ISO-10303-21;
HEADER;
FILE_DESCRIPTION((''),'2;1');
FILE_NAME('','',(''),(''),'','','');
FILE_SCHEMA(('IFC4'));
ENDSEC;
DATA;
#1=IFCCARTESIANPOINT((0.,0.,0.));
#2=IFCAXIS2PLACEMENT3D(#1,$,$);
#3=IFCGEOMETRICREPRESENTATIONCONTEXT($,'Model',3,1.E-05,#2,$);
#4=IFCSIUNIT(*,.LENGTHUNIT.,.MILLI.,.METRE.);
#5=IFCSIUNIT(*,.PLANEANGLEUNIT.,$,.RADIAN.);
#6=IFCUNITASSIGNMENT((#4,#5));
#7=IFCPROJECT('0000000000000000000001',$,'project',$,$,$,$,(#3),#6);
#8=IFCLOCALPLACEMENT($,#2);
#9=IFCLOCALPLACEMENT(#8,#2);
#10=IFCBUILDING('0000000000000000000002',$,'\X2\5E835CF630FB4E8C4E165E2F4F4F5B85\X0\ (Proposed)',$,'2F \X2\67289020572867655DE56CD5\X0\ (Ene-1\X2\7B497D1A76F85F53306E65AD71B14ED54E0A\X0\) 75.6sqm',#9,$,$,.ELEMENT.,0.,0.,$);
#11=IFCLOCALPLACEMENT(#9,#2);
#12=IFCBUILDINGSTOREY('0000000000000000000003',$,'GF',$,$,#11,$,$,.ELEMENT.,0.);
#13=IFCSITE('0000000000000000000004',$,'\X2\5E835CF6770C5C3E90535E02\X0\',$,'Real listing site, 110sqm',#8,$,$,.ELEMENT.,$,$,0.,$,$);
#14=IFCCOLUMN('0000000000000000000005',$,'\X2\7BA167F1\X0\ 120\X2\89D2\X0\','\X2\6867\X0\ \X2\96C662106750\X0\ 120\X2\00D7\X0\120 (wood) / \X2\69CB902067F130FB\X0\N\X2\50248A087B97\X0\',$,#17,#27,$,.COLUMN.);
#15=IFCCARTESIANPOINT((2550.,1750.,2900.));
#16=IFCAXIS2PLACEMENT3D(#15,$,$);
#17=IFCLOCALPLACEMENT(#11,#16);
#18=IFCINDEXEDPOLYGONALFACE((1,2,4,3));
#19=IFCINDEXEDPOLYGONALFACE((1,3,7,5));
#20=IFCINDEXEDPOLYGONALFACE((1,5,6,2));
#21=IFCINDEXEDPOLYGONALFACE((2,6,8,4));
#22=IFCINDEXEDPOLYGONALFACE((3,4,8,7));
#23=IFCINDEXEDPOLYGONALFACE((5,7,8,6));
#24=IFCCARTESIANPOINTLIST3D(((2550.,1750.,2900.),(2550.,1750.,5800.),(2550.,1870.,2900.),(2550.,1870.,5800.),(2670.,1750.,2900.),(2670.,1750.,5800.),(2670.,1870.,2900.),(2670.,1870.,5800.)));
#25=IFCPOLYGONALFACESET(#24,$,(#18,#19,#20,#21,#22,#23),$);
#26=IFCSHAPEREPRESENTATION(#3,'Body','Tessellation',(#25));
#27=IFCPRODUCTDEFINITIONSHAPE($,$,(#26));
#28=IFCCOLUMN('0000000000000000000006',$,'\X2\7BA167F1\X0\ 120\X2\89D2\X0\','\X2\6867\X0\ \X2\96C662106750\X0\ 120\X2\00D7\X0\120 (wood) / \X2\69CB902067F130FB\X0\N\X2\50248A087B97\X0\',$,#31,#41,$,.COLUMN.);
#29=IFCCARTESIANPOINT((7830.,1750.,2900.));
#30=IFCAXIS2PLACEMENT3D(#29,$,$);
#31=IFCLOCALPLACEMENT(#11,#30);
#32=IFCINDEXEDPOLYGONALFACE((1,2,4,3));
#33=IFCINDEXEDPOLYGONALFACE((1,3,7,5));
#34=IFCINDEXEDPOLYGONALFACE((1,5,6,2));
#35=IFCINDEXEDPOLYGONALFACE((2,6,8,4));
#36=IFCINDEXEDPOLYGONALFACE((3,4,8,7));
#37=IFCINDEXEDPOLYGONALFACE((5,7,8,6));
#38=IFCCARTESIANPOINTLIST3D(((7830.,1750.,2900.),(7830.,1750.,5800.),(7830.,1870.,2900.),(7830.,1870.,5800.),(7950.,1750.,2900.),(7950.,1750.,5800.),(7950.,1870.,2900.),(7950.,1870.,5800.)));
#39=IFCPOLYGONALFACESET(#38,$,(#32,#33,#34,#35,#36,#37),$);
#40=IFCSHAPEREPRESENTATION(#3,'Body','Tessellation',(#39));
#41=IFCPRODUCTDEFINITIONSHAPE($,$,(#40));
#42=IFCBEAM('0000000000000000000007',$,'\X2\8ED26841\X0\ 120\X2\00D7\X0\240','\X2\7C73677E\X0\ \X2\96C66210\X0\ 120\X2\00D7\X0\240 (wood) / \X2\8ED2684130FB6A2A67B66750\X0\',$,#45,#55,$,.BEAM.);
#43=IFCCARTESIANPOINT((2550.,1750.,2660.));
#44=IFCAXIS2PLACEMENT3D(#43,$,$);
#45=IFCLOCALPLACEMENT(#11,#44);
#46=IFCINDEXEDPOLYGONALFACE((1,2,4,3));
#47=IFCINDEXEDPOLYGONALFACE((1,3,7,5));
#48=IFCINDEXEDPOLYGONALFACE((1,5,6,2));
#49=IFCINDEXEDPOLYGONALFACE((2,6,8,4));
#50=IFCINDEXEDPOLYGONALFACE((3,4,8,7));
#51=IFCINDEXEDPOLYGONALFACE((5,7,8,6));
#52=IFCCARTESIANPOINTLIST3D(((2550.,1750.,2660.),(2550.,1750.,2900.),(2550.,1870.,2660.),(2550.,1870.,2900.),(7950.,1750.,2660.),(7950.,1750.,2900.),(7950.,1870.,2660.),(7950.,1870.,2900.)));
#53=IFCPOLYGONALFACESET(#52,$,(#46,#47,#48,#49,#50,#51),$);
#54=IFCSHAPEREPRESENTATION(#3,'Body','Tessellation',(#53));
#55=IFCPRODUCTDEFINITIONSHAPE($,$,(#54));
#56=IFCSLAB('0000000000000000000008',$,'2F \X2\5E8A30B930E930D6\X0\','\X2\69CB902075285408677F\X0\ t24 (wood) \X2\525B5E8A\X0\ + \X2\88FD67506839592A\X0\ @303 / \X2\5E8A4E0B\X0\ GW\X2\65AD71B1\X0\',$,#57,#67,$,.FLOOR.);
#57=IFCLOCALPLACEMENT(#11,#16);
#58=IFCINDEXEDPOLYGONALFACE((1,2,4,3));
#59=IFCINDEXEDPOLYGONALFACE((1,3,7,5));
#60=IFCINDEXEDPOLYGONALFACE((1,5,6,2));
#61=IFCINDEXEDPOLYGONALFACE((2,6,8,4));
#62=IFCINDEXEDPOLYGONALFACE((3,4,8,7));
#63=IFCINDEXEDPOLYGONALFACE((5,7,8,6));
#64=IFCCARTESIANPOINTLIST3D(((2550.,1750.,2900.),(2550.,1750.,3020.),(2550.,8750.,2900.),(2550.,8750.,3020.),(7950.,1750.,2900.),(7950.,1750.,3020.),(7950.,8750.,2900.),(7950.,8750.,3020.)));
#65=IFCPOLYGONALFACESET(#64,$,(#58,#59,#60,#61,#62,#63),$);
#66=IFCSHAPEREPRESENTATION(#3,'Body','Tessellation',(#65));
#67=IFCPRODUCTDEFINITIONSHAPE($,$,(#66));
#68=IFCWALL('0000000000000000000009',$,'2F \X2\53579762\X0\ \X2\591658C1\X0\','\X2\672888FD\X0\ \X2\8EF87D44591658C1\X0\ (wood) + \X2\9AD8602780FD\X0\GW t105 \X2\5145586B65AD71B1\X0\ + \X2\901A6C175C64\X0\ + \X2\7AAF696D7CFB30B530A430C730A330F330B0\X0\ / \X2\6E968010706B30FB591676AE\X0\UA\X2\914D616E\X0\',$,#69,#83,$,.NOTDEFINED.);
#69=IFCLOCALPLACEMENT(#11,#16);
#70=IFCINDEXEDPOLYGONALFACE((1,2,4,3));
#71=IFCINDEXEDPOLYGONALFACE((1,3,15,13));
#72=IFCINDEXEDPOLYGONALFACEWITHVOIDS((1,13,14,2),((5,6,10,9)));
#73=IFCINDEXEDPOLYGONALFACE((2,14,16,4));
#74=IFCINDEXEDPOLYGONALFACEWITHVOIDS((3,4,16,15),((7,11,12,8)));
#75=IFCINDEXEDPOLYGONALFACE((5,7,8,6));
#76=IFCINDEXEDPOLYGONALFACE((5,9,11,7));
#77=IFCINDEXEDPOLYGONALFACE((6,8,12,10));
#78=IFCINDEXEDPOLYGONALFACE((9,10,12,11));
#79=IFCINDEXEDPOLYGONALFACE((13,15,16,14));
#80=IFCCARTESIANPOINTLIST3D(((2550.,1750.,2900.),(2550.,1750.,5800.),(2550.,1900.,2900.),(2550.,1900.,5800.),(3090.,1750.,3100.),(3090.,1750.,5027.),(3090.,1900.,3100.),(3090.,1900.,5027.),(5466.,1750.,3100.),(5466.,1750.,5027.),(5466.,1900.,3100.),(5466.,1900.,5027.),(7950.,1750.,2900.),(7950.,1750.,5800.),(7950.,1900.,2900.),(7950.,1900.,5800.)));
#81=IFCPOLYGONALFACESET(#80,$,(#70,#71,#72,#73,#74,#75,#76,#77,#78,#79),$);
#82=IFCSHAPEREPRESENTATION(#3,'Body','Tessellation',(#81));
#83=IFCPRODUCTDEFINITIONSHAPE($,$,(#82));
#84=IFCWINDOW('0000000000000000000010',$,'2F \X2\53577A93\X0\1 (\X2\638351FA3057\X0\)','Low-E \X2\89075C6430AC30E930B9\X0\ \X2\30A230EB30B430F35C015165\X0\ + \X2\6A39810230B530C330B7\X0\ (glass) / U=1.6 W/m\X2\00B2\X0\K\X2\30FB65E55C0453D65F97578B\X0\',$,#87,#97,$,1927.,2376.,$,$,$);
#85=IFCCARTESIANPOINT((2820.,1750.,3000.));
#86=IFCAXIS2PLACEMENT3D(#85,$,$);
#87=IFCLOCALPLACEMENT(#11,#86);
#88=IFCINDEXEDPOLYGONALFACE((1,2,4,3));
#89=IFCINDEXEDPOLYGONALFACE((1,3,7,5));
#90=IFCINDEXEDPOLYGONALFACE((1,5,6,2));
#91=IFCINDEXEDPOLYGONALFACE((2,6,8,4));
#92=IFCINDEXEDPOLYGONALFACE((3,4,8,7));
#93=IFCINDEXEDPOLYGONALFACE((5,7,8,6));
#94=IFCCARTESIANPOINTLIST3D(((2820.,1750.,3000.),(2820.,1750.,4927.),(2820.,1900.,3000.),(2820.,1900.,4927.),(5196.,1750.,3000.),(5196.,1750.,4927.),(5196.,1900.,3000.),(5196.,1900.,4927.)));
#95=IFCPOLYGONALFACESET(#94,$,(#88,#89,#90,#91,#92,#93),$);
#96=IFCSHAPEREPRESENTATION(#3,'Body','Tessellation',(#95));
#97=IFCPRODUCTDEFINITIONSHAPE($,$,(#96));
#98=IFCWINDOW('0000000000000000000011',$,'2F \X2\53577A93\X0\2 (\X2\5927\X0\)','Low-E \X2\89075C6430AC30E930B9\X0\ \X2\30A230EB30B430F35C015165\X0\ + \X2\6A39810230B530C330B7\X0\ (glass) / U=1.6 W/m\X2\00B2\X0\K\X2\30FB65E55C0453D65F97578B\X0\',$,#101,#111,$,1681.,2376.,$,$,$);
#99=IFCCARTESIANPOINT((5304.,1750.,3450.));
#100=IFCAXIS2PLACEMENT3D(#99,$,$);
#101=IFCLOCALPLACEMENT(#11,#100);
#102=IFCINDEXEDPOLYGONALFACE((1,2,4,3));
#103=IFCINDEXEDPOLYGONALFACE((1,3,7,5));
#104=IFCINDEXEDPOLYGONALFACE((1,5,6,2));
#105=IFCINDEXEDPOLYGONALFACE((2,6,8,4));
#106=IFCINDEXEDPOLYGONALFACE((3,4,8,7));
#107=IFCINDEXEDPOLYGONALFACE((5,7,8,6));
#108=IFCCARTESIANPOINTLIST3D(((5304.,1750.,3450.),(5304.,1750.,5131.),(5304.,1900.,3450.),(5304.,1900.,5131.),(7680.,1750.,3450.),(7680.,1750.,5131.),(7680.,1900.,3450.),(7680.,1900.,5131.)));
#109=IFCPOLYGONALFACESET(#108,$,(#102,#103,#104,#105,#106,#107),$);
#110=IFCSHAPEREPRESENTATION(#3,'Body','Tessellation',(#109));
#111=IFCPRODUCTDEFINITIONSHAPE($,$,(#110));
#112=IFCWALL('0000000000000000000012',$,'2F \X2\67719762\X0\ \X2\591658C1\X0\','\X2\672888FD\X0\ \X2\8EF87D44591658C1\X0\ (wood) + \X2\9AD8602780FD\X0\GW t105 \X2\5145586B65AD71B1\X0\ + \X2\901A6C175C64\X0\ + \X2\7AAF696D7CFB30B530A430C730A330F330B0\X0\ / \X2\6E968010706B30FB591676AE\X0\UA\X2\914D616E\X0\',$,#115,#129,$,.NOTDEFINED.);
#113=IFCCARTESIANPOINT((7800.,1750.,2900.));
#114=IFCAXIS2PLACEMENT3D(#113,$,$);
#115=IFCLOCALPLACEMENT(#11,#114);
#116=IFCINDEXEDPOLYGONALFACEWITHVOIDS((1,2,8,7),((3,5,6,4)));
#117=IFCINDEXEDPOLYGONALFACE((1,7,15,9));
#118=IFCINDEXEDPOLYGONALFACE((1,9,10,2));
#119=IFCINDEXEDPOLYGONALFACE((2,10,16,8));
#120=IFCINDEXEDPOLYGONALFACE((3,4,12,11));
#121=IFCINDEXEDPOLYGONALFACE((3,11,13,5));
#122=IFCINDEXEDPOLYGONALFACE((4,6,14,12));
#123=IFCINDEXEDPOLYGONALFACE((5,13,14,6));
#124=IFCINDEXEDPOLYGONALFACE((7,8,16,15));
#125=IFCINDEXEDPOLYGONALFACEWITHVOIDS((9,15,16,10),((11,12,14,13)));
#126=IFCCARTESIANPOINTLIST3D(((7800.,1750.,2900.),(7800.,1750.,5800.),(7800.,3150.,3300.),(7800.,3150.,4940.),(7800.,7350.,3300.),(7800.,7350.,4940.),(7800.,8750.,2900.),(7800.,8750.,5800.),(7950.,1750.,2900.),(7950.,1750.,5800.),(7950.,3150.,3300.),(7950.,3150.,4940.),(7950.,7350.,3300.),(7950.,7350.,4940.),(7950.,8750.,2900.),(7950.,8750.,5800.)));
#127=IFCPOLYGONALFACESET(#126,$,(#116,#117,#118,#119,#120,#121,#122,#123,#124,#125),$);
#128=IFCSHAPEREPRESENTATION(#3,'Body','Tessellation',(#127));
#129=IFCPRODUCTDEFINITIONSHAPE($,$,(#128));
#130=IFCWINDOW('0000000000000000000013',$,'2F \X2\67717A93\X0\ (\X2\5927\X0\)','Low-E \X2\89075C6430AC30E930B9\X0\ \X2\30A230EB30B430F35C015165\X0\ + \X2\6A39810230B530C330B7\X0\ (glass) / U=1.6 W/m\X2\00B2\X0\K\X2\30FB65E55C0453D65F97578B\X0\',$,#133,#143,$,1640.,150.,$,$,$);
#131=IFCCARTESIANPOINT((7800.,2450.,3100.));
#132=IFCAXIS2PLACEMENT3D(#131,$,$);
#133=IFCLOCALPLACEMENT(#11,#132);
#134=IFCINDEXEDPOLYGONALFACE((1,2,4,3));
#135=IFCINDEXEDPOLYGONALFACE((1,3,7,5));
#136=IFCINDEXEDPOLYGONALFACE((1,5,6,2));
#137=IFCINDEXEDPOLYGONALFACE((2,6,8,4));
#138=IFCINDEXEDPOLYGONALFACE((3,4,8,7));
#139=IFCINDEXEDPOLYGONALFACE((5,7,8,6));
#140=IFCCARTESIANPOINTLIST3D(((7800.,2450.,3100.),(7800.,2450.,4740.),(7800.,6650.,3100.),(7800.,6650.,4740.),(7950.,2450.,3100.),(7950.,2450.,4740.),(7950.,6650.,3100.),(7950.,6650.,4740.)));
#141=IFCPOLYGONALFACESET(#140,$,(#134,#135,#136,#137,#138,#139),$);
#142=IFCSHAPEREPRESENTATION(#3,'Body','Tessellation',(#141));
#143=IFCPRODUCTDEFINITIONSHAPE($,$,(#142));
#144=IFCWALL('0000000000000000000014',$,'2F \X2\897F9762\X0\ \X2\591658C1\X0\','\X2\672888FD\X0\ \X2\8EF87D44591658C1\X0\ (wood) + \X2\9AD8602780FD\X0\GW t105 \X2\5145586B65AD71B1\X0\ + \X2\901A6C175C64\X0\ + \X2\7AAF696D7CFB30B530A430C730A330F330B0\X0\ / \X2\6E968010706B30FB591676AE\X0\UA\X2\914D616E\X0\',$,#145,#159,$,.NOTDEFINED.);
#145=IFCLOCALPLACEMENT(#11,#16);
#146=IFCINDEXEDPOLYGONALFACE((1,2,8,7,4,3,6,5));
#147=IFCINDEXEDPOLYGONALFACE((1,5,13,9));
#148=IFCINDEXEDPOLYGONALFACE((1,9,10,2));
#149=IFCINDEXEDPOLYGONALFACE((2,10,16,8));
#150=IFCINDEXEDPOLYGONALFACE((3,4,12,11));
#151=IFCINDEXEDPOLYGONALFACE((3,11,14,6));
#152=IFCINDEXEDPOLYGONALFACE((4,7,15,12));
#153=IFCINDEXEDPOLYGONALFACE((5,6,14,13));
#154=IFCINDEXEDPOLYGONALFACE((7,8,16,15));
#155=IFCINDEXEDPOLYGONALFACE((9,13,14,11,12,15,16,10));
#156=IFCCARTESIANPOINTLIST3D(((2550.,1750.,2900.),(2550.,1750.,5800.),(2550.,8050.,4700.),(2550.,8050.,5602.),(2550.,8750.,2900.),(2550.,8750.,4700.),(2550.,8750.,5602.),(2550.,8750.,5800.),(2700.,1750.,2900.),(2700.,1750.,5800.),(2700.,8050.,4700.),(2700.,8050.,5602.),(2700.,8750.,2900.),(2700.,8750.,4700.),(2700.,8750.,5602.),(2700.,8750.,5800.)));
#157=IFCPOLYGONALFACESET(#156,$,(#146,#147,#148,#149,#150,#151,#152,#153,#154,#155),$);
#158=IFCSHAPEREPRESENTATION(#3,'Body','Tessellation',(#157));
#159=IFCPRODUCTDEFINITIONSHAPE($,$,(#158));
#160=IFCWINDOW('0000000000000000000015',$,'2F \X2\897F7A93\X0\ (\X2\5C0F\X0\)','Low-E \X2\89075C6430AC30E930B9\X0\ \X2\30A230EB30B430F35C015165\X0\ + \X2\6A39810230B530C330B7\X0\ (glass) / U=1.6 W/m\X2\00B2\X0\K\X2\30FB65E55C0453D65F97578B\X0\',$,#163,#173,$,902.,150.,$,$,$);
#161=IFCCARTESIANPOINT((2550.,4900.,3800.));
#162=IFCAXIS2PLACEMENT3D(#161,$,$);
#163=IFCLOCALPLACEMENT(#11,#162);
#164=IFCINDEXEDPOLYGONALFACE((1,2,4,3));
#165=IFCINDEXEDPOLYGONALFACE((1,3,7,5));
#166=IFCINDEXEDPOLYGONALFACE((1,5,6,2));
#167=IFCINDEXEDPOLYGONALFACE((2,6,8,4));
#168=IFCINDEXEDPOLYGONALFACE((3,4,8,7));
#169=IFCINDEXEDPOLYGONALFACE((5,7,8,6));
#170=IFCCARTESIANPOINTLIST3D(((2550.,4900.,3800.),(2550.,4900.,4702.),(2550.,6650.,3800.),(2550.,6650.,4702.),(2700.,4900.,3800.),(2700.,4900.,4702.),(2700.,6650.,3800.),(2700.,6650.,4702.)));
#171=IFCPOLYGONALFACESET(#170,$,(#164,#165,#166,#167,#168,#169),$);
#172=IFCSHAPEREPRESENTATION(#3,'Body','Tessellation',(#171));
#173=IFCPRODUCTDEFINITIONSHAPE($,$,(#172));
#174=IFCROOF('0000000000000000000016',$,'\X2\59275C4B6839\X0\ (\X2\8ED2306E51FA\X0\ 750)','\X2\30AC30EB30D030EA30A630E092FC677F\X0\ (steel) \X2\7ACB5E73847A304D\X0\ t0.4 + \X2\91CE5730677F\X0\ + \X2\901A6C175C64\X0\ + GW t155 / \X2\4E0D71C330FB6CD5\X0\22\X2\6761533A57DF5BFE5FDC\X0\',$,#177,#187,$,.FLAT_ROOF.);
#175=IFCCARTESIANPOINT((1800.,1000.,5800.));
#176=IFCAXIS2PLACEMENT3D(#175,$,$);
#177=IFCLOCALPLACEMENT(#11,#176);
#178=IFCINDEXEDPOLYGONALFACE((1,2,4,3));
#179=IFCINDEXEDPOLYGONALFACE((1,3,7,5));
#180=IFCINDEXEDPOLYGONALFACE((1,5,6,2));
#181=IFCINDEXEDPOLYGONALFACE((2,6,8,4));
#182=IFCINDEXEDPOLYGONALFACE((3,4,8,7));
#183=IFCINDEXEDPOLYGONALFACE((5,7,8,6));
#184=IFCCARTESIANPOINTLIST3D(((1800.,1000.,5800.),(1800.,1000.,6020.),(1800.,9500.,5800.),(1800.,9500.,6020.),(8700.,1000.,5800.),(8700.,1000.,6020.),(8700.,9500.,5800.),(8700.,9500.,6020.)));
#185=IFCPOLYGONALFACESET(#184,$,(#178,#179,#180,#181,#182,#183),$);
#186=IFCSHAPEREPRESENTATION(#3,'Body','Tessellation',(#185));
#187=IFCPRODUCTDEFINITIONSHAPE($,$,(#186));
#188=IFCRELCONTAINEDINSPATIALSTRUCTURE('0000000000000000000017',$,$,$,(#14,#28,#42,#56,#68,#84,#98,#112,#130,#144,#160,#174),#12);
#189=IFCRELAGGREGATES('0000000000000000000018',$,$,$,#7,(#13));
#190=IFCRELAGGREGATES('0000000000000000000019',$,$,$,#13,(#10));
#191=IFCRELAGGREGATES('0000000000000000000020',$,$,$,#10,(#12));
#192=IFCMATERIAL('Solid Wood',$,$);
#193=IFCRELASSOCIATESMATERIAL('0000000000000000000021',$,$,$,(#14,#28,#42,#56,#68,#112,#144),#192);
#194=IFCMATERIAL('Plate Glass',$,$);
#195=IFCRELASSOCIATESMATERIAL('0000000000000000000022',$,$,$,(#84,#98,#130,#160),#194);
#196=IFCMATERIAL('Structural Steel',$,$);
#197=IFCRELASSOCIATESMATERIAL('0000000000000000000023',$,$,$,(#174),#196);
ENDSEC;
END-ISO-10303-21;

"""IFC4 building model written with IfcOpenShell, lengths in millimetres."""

from ifc_helpers import new_model, si_unit, frame, frame_2d, origin, place, context, project, spatial, rectangle, extrude, material, element, fill, save


model = new_model("IFC4")

# Units and contexts
model_context = context("Model", 3, precision=1e-05, world=origin())
ifc_project = project(units=[si_unit("LENGTHUNIT", "METRE", prefix="MILLI"), si_unit("PLANEANGLEUNIT", "RADIAN")], contexts=[model_context])

# Site, building, storey
site_placement = place(None, origin())
site = spatial("IfcSite", under=ifc_project, at=site_placement, Name="広島県尾道市", ObjectType="Real listing site, 110sqm", CompositionType="ELEMENT", RefElevation=0.0)
building_placement = place(site_placement, origin())
building = spatial("IfcBuilding", under=site, at=building_placement, Name="広島・二世帯住宅 (Proposed)", ObjectType="2F 木造在来工法 (Ene-1等級相当の断熱仕上) 75.6sqm", CompositionType="ELEMENT", ElevationOfRefHeight=0.0, ElevationOfTerrain=0.0)
storey_placement = place(building_placement, origin())
storey = spatial("IfcBuildingStorey", under=building, at=storey_placement, Name="GF", CompositionType="ELEMENT", Elevation=0.0)

# Columns
ifc_material_1 = material(Name="Solid Wood")
column_1_placement = place(storey_placement, frame((2550.0, 1750.0, 2900.0)))
element("IfcColumn", 1, at=column_1_placement, inside=storey, material=ifc_material_1, Name="管柱 120角", Description="桧 集成材 120×120 (wood) / 構造柱・N値計算", PredefinedType="COLUMN", context=model_context, shape_type="SweptSolid", body=[
    extrude(rectangle(XDim=120.0, YDim=120.0, at=frame_2d((60.0, 60.0))), frame((2550.0, 1750.0, 2900.0)), (0.0, 0.0, 1.0), 2900.0),
])
column_2_placement = place(storey_placement, frame((7830.0, 1750.0, 2900.0)))
element("IfcColumn", 2, at=column_2_placement, inside=storey, material=ifc_material_1, Name="管柱 120角", Description="桧 集成材 120×120 (wood) / 構造柱・N値計算", PredefinedType="COLUMN", context=model_context, shape_type="SweptSolid", body=[
    extrude(rectangle(XDim=120.0, YDim=120.0, at=frame_2d((60.0, 60.0))), frame((7830.0, 1750.0, 2900.0)), (0.0, 0.0, 1.0), 2900.0),
])

# Beam
beam_1_placement = place(storey_placement, frame((2550.0, 1750.0, 2660.0)))
element("IfcBeam", 3, at=beam_1_placement, inside=storey, material=ifc_material_1, Name="軒桁 120×240", Description="米松 集成 120×240 (wood) / 軒桁・横架材", PredefinedType="BEAM", context=model_context, shape_type="SweptSolid", body=[
    extrude(rectangle(XDim=5400.0, YDim=120.0, at=frame_2d((2700.0, 60.0))), frame((2550.0, 1750.0, 2660.0)), (0.0, 0.0, 1.0), 240.0),
])

# Slab
slab_placement = place(storey_placement, frame((2550.0, 1750.0, 2900.0)))
element("IfcSlab", 4, at=slab_placement, inside=storey, material=ifc_material_1, Name="2F 床スラブ", Description="構造用合板 t24 (wood) 剛床 + 製材根太 @303 / 床下 GW断熱", PredefinedType="FLOOR", context=model_context, shape_type="SweptSolid", body=[
    extrude(rectangle(XDim=5400.0, YDim=7000.0, at=frame_2d((2700.0, 3500.0))), frame((2550.0, 1750.0, 2900.0)), (0.0, 0.0, 1.0), 120.0),
])

# Wall, openings, windows
wall_1_placement = place(storey_placement, frame((2550.0, 1750.0, 2900.0)))
wall_1 = element("IfcWall", 5, at=wall_1_placement, inside=storey, material=ifc_material_1, Name="2F 南面 外壁", Description="木製 軸組外壁 (wood) + 高性能GW t105 充填断熱 + 通気層 + 窯業系サイディング / 準耐火・外皮UA配慮", PredefinedType="NOTDEFINED", context=model_context, shape_type="SweptSolid", body=[
    extrude(rectangle(XDim=5400.0, YDim=150.0, at=frame_2d((2700.0, 75.0))), frame((2550.0, 1750.0, 2900.0)), (0.0, 0.0, 1.0), 2900.0),
])
opening_1_placement = place(storey_placement, frame((2820.0, 1750.0, 3000.0)))
opening_1 = element("IfcOpeningElement", 6, at=opening_1_placement, cuts=wall_1, PredefinedType="NOTDEFINED", context=model_context, shape_type="SweptSolid", body=[
    extrude(rectangle(XDim=2376.0, YDim=150.0, at=frame_2d((1188.0, 75.0))), frame((2820.0, 1750.0, 3000.0)), (0.0, 0.0, 1.0), 1927.0),
])
opening_2_placement = place(storey_placement, frame((5304.0, 1750.0, 3450.0)))
opening_2 = element("IfcOpeningElement", 7, at=opening_2_placement, cuts=wall_1, PredefinedType="NOTDEFINED", context=model_context, shape_type="SweptSolid", body=[
    extrude(rectangle(XDim=2376.0, YDim=150.0, at=frame_2d((1188.0, 75.0))), frame((5304.0, 1750.0, 3450.0)), (0.0, 0.0, 1.0), 1681.0),
])
ifc_material_2 = material(Name="Plate Glass")
window_1_placement = place(storey_placement, frame((2820.0, 1750.0, 3000.0)))
window_1 = element("IfcWindow", 8, at=window_1_placement, inside=storey, material=ifc_material_2, Name="2F 南窓1 (掃出し)", Description="Low-E 複層ガラス アルゴン封入 + 樹脂サッシ (glass) / U=1.6 W/m²K・日射取得型", OverallHeight=1927.0, OverallWidth=2376.0, context=model_context, shape_type="SweptSolid", body=[
    extrude(rectangle(XDim=2376.0, YDim=150.0, at=frame_2d((1188.0, 75.0))), frame((2820.0, 1750.0, 3000.0)), (0.0, 0.0, 1.0), 1927.0),
])
fill(opening_1, window_1)
window_2_placement = place(storey_placement, frame((5304.0, 1750.0, 3450.0)))
window_2 = element("IfcWindow", 9, at=window_2_placement, inside=storey, material=ifc_material_2, Name="2F 南窓2 (大)", Description="Low-E 複層ガラス アルゴン封入 + 樹脂サッシ (glass) / U=1.6 W/m²K・日射取得型", OverallHeight=1681.0, OverallWidth=2376.0, context=model_context, shape_type="SweptSolid", body=[
    extrude(rectangle(XDim=2376.0, YDim=150.0, at=frame_2d((1188.0, 75.0))), frame((5304.0, 1750.0, 3450.0)), (0.0, 0.0, 1.0), 1681.0),
])
fill(opening_2, window_2)

# Walls, openings, windows
wall_2_placement = place(storey_placement, frame((7800.0, 1750.0, 2900.0)))
wall_2 = element("IfcWall", 10, at=wall_2_placement, inside=storey, material=ifc_material_1, Name="2F 東面 外壁", Description="木製 軸組外壁 (wood) + 高性能GW t105 充填断熱 + 通気層 + 窯業系サイディング / 準耐火・外皮UA配慮", PredefinedType="NOTDEFINED", context=model_context, shape_type="SweptSolid", body=[
    extrude(rectangle(XDim=150.0, YDim=7000.0, at=frame_2d((75.0, 3500.0))), frame((7800.0, 1750.0, 2900.0)), (0.0, 0.0, 1.0), 2900.0),
])
opening_3_placement = place(storey_placement, frame((7800.0, 2450.0, 3100.0)))
opening_3 = element("IfcOpeningElement", 11, at=opening_3_placement, cuts=wall_2, PredefinedType="NOTDEFINED", context=model_context, shape_type="SweptSolid", body=[
    extrude(rectangle(XDim=150.0, YDim=4200.0, at=frame_2d((75.0, 2100.0))), frame((7800.0, 2450.0, 3100.0)), (0.0, 0.0, 1.0), 1640.0),
])
window_3_placement = place(storey_placement, frame((7800.0, 2450.0, 3100.0)))
window_3 = element("IfcWindow", 12, at=window_3_placement, inside=storey, material=ifc_material_2, Name="2F 東窓 (大)", Description="Low-E 複層ガラス アルゴン封入 + 樹脂サッシ (glass) / U=1.6 W/m²K・日射取得型", OverallHeight=1640.0, OverallWidth=150.0, context=model_context, shape_type="SweptSolid", body=[
    extrude(rectangle(XDim=150.0, YDim=4200.0, at=frame_2d((75.0, 2100.0))), frame((7800.0, 2450.0, 3100.0)), (0.0, 0.0, 1.0), 1640.0),
])
fill(opening_3, window_3)
wall_3_placement = place(storey_placement, frame((2550.0, 1750.0, 2900.0)))
wall_3 = element("IfcWall", 13, at=wall_3_placement, inside=storey, material=ifc_material_1, Name="2F 西面 外壁", Description="木製 軸組外壁 (wood) + 高性能GW t105 充填断熱 + 通気層 + 窯業系サイディング / 準耐火・外皮UA配慮", PredefinedType="NOTDEFINED", context=model_context, shape_type="SweptSolid", body=[
    extrude(rectangle(XDim=150.0, YDim=7000.0, at=frame_2d((75.0, 3500.0))), frame((2550.0, 1750.0, 2900.0)), (0.0, 0.0, 1.0), 2900.0),
])
opening_4_placement = place(storey_placement, frame((2550.0, 4900.0, 3800.0)))
opening_4 = element("IfcOpeningElement", 14, at=opening_4_placement, cuts=wall_3, PredefinedType="NOTDEFINED", context=model_context, shape_type="SweptSolid", body=[
    extrude(rectangle(XDim=150.0, YDim=1750.0, at=frame_2d((75.0, 875.0))), frame((2550.0, 4900.0, 3800.0)), (0.0, 0.0, 1.0), 902.0),
])
window_4_placement = place(storey_placement, frame((2550.0, 4900.0, 3800.0)))
window_4 = element("IfcWindow", 15, at=window_4_placement, inside=storey, material=ifc_material_2, Name="2F 西窓 (小)", Description="Low-E 複層ガラス アルゴン封入 + 樹脂サッシ (glass) / U=1.6 W/m²K・日射取得型", OverallHeight=902.0, OverallWidth=150.0, context=model_context, shape_type="SweptSolid", body=[
    extrude(rectangle(XDim=150.0, YDim=1750.0, at=frame_2d((75.0, 875.0))), frame((2550.0, 4900.0, 3800.0)), (0.0, 0.0, 1.0), 902.0),
])
fill(opening_4, window_4)

# Roof
ifc_material_3 = material(Name="Structural Steel")
roof_placement = place(storey_placement, frame((1800.0, 1000.0, 5800.0)))
element("IfcRoof", 16, at=roof_placement, inside=storey, material=ifc_material_3, Name="大屋根 (軒の出 750)", Description="ガルバリウム鋼板 (steel) 立平葺き t0.4 + 野地板 + 通気層 + GW t155 / 不燃・法22条区域対応", PredefinedType="FLAT_ROOF", context=model_context, shape_type="SweptSolid", body=[
    extrude(rectangle(XDim=6900.0, YDim=8500.0, at=frame_2d((3450.0, 4250.0))), frame((1800.0, 1000.0, 5800.0)), (0.0, 0.0, 1.0), 220.0),
])

save(model, "model.ifc")
